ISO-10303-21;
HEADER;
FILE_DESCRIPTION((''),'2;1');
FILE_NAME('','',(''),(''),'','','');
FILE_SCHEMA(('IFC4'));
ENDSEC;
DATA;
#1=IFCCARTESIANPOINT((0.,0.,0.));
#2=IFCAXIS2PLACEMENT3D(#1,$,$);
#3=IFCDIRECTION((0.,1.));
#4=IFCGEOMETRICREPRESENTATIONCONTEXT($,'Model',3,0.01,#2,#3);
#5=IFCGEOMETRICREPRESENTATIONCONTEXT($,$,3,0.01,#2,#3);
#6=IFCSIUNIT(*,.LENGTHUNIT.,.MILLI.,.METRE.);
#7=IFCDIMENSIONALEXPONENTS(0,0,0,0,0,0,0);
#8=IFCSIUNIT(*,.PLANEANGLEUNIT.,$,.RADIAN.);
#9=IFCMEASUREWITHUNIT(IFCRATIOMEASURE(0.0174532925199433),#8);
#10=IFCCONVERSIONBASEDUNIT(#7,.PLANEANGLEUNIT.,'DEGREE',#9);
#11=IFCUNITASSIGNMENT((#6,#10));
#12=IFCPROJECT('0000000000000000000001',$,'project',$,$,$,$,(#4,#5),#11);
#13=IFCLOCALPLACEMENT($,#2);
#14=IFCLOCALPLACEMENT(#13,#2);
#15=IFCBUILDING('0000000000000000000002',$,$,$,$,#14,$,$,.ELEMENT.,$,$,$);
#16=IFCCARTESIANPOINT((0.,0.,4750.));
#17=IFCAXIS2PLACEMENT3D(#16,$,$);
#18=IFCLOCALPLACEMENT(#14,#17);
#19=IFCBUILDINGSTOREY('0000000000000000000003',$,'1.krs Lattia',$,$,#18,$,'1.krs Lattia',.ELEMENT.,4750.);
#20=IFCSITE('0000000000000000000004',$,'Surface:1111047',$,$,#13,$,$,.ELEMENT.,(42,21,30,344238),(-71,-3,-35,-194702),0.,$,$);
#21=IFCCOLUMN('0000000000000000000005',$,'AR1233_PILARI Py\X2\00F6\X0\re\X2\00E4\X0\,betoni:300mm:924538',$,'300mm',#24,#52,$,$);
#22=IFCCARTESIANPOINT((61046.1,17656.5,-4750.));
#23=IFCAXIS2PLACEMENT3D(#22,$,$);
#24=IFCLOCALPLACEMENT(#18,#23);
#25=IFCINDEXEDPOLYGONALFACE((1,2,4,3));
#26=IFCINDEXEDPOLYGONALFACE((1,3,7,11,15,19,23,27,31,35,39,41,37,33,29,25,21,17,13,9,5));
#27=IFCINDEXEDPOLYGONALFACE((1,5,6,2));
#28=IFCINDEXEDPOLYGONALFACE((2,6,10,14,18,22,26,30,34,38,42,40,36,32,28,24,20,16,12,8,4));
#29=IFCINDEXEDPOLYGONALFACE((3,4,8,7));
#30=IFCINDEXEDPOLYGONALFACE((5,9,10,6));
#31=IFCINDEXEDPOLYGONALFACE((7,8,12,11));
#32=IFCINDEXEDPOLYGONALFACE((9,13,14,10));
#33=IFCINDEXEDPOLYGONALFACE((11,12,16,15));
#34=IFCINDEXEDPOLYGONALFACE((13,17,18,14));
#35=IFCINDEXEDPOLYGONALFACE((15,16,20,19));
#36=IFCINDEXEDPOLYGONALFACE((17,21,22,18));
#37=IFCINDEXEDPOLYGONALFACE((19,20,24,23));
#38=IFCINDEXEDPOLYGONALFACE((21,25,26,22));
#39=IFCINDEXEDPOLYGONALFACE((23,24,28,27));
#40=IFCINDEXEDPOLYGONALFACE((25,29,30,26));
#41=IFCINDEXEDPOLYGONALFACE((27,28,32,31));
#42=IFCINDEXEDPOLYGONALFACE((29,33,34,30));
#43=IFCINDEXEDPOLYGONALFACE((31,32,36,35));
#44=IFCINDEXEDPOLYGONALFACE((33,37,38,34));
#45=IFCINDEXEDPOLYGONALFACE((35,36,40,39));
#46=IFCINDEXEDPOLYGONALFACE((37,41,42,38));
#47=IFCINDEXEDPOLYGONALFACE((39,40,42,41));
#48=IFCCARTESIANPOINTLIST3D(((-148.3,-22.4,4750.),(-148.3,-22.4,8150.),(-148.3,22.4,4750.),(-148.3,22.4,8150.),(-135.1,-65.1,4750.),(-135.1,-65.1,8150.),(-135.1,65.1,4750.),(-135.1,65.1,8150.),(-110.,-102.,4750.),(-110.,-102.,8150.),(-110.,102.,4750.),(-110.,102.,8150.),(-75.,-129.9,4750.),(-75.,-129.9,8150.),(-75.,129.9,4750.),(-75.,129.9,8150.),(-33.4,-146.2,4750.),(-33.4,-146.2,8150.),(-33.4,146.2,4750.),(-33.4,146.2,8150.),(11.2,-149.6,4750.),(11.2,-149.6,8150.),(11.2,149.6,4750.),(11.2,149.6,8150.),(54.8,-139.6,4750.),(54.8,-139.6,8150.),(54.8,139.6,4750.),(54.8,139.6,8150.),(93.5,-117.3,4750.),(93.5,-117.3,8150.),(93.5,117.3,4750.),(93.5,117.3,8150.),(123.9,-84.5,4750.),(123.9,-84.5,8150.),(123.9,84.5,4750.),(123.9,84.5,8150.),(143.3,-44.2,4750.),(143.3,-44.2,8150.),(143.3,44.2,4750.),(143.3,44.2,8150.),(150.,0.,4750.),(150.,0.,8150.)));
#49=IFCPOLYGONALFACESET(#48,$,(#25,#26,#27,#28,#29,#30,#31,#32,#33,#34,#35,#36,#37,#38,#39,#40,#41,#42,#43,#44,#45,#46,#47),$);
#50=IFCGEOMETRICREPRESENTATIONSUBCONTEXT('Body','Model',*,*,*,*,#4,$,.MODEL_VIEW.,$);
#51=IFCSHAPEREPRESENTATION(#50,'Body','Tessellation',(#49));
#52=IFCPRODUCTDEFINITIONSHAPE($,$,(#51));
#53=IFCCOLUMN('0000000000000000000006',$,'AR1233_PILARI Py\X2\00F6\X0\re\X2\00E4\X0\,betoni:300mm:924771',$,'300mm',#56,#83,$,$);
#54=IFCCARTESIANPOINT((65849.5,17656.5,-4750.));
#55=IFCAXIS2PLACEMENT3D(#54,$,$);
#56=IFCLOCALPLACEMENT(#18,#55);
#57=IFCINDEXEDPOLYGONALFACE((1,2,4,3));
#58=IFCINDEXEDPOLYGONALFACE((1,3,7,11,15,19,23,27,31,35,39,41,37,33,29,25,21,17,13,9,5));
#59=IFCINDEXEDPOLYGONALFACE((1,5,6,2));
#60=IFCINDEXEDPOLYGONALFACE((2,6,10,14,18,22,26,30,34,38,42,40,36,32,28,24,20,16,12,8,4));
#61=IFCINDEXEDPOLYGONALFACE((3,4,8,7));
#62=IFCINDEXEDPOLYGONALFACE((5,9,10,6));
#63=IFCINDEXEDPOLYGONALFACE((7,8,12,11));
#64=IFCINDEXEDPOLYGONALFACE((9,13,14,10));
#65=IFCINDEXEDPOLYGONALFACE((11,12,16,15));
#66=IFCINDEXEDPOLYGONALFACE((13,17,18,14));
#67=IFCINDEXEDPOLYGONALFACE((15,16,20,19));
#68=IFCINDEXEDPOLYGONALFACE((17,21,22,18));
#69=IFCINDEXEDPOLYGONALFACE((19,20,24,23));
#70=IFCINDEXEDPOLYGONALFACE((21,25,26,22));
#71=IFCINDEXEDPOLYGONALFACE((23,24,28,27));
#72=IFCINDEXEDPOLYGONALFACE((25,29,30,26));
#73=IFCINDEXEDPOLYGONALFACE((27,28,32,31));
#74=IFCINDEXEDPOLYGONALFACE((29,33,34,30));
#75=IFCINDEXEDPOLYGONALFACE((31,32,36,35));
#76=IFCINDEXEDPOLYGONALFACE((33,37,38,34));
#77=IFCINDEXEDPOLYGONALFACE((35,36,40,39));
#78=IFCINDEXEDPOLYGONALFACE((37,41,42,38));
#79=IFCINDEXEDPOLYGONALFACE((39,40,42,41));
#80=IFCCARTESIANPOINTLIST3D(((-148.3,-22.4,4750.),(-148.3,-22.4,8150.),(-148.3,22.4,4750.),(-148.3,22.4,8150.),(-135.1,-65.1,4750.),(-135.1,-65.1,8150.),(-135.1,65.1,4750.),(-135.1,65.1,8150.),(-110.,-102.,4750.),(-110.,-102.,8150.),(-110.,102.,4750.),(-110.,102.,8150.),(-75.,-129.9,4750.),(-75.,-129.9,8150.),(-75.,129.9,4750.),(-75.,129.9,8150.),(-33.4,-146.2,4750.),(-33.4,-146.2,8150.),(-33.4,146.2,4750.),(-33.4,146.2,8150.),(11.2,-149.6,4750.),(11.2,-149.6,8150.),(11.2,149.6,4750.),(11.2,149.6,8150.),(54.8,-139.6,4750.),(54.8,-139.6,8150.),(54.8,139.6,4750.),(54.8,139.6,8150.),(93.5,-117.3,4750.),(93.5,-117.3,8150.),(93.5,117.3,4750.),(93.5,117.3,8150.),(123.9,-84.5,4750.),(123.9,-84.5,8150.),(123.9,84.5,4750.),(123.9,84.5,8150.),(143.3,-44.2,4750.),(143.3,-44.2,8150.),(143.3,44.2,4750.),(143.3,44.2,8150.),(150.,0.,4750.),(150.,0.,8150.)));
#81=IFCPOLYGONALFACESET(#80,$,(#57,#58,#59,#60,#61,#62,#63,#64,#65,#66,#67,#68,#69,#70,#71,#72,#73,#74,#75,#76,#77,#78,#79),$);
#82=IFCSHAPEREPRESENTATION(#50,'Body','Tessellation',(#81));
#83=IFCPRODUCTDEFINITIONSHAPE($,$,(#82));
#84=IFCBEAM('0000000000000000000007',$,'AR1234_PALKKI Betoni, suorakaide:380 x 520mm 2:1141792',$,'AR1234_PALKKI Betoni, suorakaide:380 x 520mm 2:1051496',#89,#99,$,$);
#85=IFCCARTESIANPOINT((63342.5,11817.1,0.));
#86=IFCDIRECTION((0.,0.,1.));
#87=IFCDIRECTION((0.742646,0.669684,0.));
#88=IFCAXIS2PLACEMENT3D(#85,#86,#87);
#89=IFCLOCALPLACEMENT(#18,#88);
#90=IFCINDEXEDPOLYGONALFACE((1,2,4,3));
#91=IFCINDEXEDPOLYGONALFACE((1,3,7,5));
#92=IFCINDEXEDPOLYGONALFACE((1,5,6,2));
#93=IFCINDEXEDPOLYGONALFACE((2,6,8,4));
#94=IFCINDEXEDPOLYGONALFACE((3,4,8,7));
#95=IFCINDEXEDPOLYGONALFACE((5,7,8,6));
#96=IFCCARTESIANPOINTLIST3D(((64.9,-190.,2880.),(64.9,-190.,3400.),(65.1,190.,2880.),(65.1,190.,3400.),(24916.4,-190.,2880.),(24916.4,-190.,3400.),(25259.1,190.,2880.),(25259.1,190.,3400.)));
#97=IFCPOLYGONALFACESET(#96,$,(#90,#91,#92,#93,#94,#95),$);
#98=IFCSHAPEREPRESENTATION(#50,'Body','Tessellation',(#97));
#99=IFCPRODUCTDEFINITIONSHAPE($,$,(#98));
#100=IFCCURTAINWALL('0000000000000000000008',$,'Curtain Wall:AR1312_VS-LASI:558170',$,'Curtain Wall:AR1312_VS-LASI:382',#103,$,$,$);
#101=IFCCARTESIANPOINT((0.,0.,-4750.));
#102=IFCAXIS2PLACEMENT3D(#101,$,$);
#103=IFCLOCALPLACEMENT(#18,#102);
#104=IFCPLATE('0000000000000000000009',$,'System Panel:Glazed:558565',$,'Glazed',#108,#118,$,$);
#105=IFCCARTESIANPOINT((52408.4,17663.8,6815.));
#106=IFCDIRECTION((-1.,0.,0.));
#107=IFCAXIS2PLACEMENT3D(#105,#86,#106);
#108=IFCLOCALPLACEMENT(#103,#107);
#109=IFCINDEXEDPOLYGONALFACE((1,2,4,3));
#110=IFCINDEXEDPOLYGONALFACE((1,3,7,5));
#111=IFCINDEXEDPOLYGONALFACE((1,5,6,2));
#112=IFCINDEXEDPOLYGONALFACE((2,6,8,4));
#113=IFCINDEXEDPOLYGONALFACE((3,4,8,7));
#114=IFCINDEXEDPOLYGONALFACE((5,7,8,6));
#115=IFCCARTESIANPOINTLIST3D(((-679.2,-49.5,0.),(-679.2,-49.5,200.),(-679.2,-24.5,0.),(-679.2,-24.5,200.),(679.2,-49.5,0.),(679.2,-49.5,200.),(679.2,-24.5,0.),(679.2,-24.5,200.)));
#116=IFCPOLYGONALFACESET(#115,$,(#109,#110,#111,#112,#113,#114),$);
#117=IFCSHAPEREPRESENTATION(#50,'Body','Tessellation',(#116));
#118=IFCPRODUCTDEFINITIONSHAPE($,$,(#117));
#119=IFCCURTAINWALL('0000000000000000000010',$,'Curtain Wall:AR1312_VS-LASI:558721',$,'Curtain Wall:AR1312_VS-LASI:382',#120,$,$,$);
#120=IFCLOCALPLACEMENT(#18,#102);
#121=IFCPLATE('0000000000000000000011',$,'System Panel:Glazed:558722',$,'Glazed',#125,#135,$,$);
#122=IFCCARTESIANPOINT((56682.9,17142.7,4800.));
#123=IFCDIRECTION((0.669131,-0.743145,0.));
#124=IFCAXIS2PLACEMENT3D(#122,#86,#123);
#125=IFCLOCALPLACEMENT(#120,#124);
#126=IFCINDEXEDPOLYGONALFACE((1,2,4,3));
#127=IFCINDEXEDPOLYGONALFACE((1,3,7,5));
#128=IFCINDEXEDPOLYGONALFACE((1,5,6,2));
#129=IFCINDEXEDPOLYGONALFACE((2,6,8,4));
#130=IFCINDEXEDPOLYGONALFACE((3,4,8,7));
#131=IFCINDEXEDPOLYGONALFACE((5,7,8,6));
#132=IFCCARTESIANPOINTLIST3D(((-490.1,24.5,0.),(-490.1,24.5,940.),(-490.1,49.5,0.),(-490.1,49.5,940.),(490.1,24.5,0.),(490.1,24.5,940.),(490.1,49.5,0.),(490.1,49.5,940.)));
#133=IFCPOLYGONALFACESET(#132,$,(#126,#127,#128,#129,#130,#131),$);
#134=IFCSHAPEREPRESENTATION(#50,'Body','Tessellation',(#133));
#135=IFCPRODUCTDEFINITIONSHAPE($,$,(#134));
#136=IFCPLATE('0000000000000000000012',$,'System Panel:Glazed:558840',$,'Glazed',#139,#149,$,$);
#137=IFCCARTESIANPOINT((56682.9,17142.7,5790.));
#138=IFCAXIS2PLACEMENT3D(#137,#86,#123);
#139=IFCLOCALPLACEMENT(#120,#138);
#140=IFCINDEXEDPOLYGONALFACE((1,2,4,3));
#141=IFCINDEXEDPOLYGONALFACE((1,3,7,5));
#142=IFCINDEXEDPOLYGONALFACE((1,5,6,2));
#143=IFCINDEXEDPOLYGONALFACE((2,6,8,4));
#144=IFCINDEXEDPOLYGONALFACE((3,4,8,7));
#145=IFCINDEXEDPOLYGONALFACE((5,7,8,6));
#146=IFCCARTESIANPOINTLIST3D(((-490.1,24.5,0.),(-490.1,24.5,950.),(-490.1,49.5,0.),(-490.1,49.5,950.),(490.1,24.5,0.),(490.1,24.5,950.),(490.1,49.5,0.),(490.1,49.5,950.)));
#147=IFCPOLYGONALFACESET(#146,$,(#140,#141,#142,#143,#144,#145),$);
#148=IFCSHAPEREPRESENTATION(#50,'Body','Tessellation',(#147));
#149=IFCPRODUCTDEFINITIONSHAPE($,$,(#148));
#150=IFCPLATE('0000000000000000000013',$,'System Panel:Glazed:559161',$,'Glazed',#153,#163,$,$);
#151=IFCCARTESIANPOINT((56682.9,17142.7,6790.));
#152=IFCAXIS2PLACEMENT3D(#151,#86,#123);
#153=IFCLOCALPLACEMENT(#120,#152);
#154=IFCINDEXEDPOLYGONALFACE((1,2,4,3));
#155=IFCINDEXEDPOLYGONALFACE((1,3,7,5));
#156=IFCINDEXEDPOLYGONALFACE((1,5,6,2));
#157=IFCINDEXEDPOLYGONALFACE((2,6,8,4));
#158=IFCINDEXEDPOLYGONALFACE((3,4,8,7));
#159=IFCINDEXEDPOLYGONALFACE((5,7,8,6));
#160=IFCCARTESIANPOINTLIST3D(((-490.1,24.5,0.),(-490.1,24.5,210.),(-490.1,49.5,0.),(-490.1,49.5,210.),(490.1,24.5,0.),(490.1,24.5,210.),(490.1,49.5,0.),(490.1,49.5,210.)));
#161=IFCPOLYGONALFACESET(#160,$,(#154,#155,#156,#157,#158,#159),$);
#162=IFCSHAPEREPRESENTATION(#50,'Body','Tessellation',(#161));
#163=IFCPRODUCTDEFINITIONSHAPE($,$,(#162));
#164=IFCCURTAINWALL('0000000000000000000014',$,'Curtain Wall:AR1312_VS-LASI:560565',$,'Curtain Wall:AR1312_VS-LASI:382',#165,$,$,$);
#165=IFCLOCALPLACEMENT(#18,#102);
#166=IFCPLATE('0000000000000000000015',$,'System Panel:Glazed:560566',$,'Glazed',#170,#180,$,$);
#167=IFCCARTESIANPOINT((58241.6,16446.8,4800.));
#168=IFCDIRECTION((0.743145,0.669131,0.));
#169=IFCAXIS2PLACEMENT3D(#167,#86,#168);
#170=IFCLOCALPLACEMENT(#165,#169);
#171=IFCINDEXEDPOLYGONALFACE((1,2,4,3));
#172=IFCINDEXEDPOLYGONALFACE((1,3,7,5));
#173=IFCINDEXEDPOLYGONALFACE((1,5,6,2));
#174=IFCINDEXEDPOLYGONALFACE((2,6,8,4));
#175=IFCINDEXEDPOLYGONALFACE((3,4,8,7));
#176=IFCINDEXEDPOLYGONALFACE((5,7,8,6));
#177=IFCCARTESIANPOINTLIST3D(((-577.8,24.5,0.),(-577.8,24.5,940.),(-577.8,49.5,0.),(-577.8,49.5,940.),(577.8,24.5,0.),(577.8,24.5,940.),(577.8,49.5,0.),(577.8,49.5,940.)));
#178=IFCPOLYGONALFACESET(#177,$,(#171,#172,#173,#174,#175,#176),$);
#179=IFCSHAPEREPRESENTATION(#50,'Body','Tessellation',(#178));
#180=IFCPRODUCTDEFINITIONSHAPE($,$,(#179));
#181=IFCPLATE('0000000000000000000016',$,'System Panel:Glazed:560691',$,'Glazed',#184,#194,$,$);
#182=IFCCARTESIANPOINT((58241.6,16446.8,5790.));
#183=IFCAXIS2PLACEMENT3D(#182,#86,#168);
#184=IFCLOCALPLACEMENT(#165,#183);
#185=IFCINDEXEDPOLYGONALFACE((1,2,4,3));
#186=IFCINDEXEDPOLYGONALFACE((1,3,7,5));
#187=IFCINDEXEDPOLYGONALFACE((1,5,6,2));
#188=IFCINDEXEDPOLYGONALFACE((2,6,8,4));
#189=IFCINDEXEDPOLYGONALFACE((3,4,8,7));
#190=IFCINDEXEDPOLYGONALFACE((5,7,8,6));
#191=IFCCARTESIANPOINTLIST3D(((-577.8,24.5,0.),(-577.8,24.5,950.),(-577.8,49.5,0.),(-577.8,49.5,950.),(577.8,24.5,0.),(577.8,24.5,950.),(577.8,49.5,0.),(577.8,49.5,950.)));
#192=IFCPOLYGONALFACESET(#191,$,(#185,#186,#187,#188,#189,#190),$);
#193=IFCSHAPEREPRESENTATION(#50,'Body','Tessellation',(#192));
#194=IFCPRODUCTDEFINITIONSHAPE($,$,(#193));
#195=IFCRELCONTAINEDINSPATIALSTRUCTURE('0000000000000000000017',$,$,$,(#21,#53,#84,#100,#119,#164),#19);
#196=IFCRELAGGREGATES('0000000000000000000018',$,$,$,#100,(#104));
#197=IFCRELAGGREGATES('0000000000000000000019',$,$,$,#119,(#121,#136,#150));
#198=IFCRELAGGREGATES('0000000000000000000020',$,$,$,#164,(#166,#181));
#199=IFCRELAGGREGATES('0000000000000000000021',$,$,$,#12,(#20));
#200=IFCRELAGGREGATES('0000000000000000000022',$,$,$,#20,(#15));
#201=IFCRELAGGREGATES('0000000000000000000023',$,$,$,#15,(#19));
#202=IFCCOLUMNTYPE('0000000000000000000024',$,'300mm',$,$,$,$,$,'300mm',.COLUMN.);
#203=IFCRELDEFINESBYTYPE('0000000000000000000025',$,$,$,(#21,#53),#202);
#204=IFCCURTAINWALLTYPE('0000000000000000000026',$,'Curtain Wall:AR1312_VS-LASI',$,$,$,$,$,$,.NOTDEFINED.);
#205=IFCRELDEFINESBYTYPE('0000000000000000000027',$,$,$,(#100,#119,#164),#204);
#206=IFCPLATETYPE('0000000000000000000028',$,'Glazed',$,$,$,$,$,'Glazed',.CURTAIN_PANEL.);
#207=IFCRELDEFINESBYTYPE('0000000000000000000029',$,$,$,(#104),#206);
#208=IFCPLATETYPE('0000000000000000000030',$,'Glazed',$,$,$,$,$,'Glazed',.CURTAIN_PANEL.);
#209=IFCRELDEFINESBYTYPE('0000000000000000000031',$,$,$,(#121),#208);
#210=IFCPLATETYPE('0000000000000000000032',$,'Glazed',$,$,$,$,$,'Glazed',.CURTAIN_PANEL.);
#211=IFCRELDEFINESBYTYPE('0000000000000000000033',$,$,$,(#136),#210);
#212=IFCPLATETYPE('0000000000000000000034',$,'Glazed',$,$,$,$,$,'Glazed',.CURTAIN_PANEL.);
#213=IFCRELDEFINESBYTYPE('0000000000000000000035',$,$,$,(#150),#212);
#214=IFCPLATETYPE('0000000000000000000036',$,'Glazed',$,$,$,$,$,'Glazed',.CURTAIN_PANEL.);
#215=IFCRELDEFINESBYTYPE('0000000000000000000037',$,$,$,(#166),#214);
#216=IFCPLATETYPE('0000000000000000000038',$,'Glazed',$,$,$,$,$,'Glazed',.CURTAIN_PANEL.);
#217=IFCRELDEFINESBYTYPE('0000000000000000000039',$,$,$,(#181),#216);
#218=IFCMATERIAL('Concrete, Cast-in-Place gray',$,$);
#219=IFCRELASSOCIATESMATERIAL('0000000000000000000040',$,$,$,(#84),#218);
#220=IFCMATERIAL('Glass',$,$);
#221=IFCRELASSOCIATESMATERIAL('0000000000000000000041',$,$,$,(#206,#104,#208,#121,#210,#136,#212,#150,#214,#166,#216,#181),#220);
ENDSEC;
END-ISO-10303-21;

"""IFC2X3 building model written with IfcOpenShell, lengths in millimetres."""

from ifc_helpers import new_model, entity, si_unit, converted_unit, direction, frame, frame_2d, origin, origin_2d_with_axis, place, context, subcontext, project, spatial, rectangle, circle, extrude, clip, halfspace, source, transform, mapped, material, type_object, type_shapes, element, aggregate, save


model = new_model("IFC2X3")

# Units and contexts
model_context = context("Model", 3, precision=0.01, world=origin(), true_north=direction((0.0, 1.0)))
context_of_model = context(None, 3, precision=0.01, world=origin(), true_north=direction((0.0, 1.0)))
body_context = subcontext(model_context, "Body", "Model", "MODEL_VIEW")
ifc_project = project(units=[si_unit("LENGTHUNIT", "METRE", prefix="MILLI"), converted_unit("PLANEANGLEUNIT", "DEGREE", entity("IfcRatioMeasure", 0.0174532925199433), si_unit("PLANEANGLEUNIT", "RADIAN"), dimensions=[0, 0, 0, 0, 0, 0, 0])], contexts=[model_context, context_of_model])

# Site, building, storey
site_placement = place(None, origin())
site = spatial("IfcSite", under=ifc_project, at=site_placement, Name="Surface:1111047", CompositionType="ELEMENT", RefLatitude=(42, 21, 30, 344238), RefLongitude=(-71, -3, -35, -194702), RefElevation=0.0)
building_placement = place(site_placement, origin())
building = spatial("IfcBuilding", under=site, at=building_placement, CompositionType="ELEMENT")
storey_placement = place(building_placement, frame((0.0, 0.0, 4750.0)))
storey = spatial("IfcBuildingStorey", under=building, at=storey_placement, Name="1.krs Lattia", LongName="1.krs Lattia", CompositionType="ELEMENT", Elevation=4750.0)

# Columns
column_type = type_object("IfcColumnType", Name="300mm", ElementType="300mm", PredefinedType="COLUMN")
shared_shape_1 = source(origin(), body_context, "Body", "SweptSolid", [
    extrude(circle(Radius=150.0, at=frame_2d((0.0, 0.0), x_axis=(1.0, 0.0))), frame((0.0, 0.0, 4750.0)), (0.0, 0.0, 1.0), 3400.0),
])
type_shapes(column_type, [shared_shape_1])
for number, where, name in (
    (1, (61046.1, 17656.5, -4750.0), "AR1233_PILARI Pyöreä,betoni:300mm:924538"),
    (2, (65849.5, 17656.5, -4750.0), "AR1233_PILARI Pyöreä,betoni:300mm:924771"),
):
    element("IfcColumn", number, at=place(storey_placement, frame(where)), inside=storey, type_object=column_type, Name=name, ObjectType="300mm", context=body_context, shape_type="MappedRepresentation", body=[
        mapped(shared_shape_1, transform((0.0, 0.0, 0.0), scale=1.0)),
    ])

# Beam
ifc_material_1 = material(Name="Concrete, Cast-in-Place gray")
beam_1_placement = place(storey_placement, frame((63342.5, 11817.1, 0.0), z_axis=(0.0, 0.0, 1.0), x_axis=(0.742646, 0.669684, 0.0)))
element("IfcBeam", 3, at=beam_1_placement, inside=storey, material=ifc_material_1, Name="AR1234_PALKKI Betoni, suorakaide:380 x 520mm 2:1141792", ObjectType="AR1234_PALKKI Betoni, suorakaide:380 x 520mm 2:1051496", context=body_context, shape_type="Clipping", body=[
    clip(clip(extrude(rectangle(XDim=520.0, YDim=380.0, at=frame_2d((0.0, 0.0), x_axis=(1.0, 0.0))), frame((64.9, 0.0, 3140.0), z_axis=(1.0, 0.0, 0.0), x_axis=(0.0, 0.0, -1.0)), (0.0, 0.0, 1.0), 25194.2), halfspace(frame((70.1, 6788.6, 0.0), z_axis=(-1.0, 0.000745, 0.0), x_axis=(-0.000745, -1.0, 0.0)), False)), halfspace(frame((24693.6, -437.1, 2880.0), z_axis=(0.742646, -0.669684, 0.0), x_axis=(0.669684, 0.742646, 0.0)), False)),
])

# Curtain wall, plate
curtain_wall_type_1 = type_object("IfcCurtainWallType", Name="Curtain Wall:AR1312_VS-LASI", PredefinedType="NOTDEFINED")
curtain_wall_1_placement = place(storey_placement, frame((0.0, 0.0, -4750.0)))
curtain_wall_1 = element("IfcCurtainWall", 4, at=curtain_wall_1_placement, inside=storey, type_object=curtain_wall_type_1, Name="Curtain Wall:AR1312_VS-LASI:558170", ObjectType="Curtain Wall:AR1312_VS-LASI:382")
ifc_material_2 = material(Name="Glass")
plate_type_1 = type_object("IfcPlateType", Name="Glazed", ElementType="Glazed", PredefinedType="CURTAIN_PANEL", material=ifc_material_2)
shared_shape_2 = source(origin(), body_context, "Body", "SweptSolid", [
    extrude(rectangle(XDim=25.0, YDim=1358.3, at=frame_2d((0.0, 0.0), x_axis=(1.0, 0.0))), frame((0.0, -37.0, 0.0), z_axis=(0.0, 0.0, 1.0), x_axis=(0.0, 1.0, 0.0)), (0.0, 0.0, 1.0), 200.0),
])
type_shapes(plate_type_1, [shared_shape_2])
plate_1_placement = place(curtain_wall_1_placement, frame((52408.4, 17663.8, 6815.0), z_axis=(0.0, 0.0, 1.0), x_axis=(-1.0, 0.0, 0.0)))
plate_1 = element("IfcPlate", 5, at=plate_1_placement, type_object=plate_type_1, material=ifc_material_2, Name="System Panel:Glazed:558565", ObjectType="Glazed", context=body_context, shape_type="MappedRepresentation", body=[
    mapped(shared_shape_2, transform((0.0, 0.0, 0.0), scale=1.0)),
])
aggregate(curtain_wall_1, [plate_1])

# Curtain walls, plates
curtain_wall_2_placement = place(storey_placement, frame((0.0, 0.0, -4750.0)))
curtain_wall_2 = element("IfcCurtainWall", 6, at=curtain_wall_2_placement, inside=storey, type_object=curtain_wall_type_1, Name="Curtain Wall:AR1312_VS-LASI:558721", ObjectType="Curtain Wall:AR1312_VS-LASI:382")
plate_type_2 = type_object("IfcPlateType", Name="Glazed", ElementType="Glazed", PredefinedType="CURTAIN_PANEL", material=ifc_material_2)
shared_shape_3 = source(origin(), body_context, "Body", "SweptSolid", [
    extrude(rectangle(XDim=25.0, YDim=980.3, at=origin_2d_with_axis()), frame((0.0, 37.0, 0.0), z_axis=(0.0, 0.0, 1.0), x_axis=(0.0, 1.0, 0.0)), (0.0, 0.0, 1.0), 940.0),
])
type_shapes(plate_type_2, [shared_shape_3])
plate_2_placement = place(curtain_wall_2_placement, frame((56682.9, 17142.7, 4800.0), z_axis=(0.0, 0.0, 1.0), x_axis=(0.669131, -0.743145, 0.0)))
plate_2 = element("IfcPlate", 7, at=plate_2_placement, type_object=plate_type_2, material=ifc_material_2, Name="System Panel:Glazed:558722", ObjectType="Glazed", context=body_context, shape_type="MappedRepresentation", body=[
    mapped(shared_shape_3, transform((0.0, 0.0, 0.0), scale=1.0)),
])
plate_type_3 = type_object("IfcPlateType", Name="Glazed", ElementType="Glazed", PredefinedType="CURTAIN_PANEL", material=ifc_material_2)
shared_shape_4 = source(origin(), body_context, "Body", "SweptSolid", [
    extrude(rectangle(XDim=25.0, YDim=980.3, at=origin_2d_with_axis()), frame((0.0, 37.0, 0.0), z_axis=(0.0, 0.0, 1.0), x_axis=(0.0, 1.0, 0.0)), (0.0, 0.0, 1.0), 950.0),
])
type_shapes(plate_type_3, [shared_shape_4])
plate_3_placement = place(curtain_wall_2_placement, frame((56682.9, 17142.7, 5790.0), z_axis=(0.0, 0.0, 1.0), x_axis=(0.669131, -0.743145, 0.0)))
plate_3 = element("IfcPlate", 8, at=plate_3_placement, type_object=plate_type_3, material=ifc_material_2, Name="System Panel:Glazed:558840", ObjectType="Glazed", context=body_context, shape_type="MappedRepresentation", body=[
    mapped(shared_shape_4, transform((0.0, 0.0, 0.0), scale=1.0)),
])
plate_type_4 = type_object("IfcPlateType", Name="Glazed", ElementType="Glazed", PredefinedType="CURTAIN_PANEL", material=ifc_material_2)
shared_shape_5 = source(origin(), body_context, "Body", "SweptSolid", [
    extrude(rectangle(XDim=25.0, YDim=980.3, at=origin_2d_with_axis()), frame((0.0, 37.0, 0.0), z_axis=(0.0, 0.0, 1.0), x_axis=(0.0, 1.0, 0.0)), (0.0, 0.0, 1.0), 210.0),
])
type_shapes(plate_type_4, [shared_shape_5])
plate_4_placement = place(curtain_wall_2_placement, frame((56682.9, 17142.7, 6790.0), z_axis=(0.0, 0.0, 1.0), x_axis=(0.669131, -0.743145, 0.0)))
plate_4 = element("IfcPlate", 9, at=plate_4_placement, type_object=plate_type_4, material=ifc_material_2, Name="System Panel:Glazed:559161", ObjectType="Glazed", context=body_context, shape_type="MappedRepresentation", body=[
    mapped(shared_shape_5, transform((0.0, 0.0, 0.0), scale=1.0)),
])
aggregate(curtain_wall_2, [plate_2, plate_3, plate_4])
curtain_wall_3_placement = place(storey_placement, frame((0.0, 0.0, -4750.0)))
curtain_wall_3 = element("IfcCurtainWall", 10, at=curtain_wall_3_placement, inside=storey, type_object=curtain_wall_type_1, Name="Curtain Wall:AR1312_VS-LASI:560565", ObjectType="Curtain Wall:AR1312_VS-LASI:382")
plate_type_5 = type_object("IfcPlateType", Name="Glazed", ElementType="Glazed", PredefinedType="CURTAIN_PANEL", material=ifc_material_2)
shared_shape_6 = source(origin(), body_context, "Body", "SweptSolid", [
    extrude(rectangle(XDim=25.0, YDim=1155.6, at=frame_2d((0.0, 0.0), x_axis=(1.0, 0.0))), frame((0.0, 37.0, 0.0), z_axis=(0.0, 0.0, 1.0), x_axis=(0.0, 1.0, 0.0)), (0.0, 0.0, 1.0), 940.0),
])
type_shapes(plate_type_5, [shared_shape_6])
plate_5_placement = place(curtain_wall_3_placement, frame((58241.6, 16446.8, 4800.0), z_axis=(0.0, 0.0, 1.0), x_axis=(0.743145, 0.669131, 0.0)))
plate_5 = element("IfcPlate", 11, at=plate_5_placement, type_object=plate_type_5, material=ifc_material_2, Name="System Panel:Glazed:560566", ObjectType="Glazed", context=body_context, shape_type="MappedRepresentation", body=[
    mapped(shared_shape_6, transform((0.0, 0.0, 0.0), scale=1.0)),
])
plate_type_6 = type_object("IfcPlateType", Name="Glazed", ElementType="Glazed", PredefinedType="CURTAIN_PANEL", material=ifc_material_2)
shared_shape_7 = source(origin(), body_context, "Body", "SweptSolid", [
    extrude(rectangle(XDim=25.0, YDim=1155.6, at=frame_2d((0.0, 0.0), x_axis=(1.0, 0.0))), frame((0.0, 37.0, 0.0), z_axis=(0.0, 0.0, 1.0), x_axis=(0.0, 1.0, 0.0)), (0.0, 0.0, 1.0), 950.0),
])
type_shapes(plate_type_6, [shared_shape_7])
plate_6_placement = place(curtain_wall_3_placement, frame((58241.6, 16446.8, 5790.0), z_axis=(0.0, 0.0, 1.0), x_axis=(0.743145, 0.669131, 0.0)))
plate_6 = element("IfcPlate", 12, at=plate_6_placement, type_object=plate_type_6, material=ifc_material_2, Name="System Panel:Glazed:560691", ObjectType="Glazed", context=body_context, shape_type="MappedRepresentation", body=[
    mapped(shared_shape_7, transform((0.0, 0.0, 0.0), scale=1.0)),
])
aggregate(curtain_wall_3, [plate_5, plate_6])

save(model, "model.ifc")
